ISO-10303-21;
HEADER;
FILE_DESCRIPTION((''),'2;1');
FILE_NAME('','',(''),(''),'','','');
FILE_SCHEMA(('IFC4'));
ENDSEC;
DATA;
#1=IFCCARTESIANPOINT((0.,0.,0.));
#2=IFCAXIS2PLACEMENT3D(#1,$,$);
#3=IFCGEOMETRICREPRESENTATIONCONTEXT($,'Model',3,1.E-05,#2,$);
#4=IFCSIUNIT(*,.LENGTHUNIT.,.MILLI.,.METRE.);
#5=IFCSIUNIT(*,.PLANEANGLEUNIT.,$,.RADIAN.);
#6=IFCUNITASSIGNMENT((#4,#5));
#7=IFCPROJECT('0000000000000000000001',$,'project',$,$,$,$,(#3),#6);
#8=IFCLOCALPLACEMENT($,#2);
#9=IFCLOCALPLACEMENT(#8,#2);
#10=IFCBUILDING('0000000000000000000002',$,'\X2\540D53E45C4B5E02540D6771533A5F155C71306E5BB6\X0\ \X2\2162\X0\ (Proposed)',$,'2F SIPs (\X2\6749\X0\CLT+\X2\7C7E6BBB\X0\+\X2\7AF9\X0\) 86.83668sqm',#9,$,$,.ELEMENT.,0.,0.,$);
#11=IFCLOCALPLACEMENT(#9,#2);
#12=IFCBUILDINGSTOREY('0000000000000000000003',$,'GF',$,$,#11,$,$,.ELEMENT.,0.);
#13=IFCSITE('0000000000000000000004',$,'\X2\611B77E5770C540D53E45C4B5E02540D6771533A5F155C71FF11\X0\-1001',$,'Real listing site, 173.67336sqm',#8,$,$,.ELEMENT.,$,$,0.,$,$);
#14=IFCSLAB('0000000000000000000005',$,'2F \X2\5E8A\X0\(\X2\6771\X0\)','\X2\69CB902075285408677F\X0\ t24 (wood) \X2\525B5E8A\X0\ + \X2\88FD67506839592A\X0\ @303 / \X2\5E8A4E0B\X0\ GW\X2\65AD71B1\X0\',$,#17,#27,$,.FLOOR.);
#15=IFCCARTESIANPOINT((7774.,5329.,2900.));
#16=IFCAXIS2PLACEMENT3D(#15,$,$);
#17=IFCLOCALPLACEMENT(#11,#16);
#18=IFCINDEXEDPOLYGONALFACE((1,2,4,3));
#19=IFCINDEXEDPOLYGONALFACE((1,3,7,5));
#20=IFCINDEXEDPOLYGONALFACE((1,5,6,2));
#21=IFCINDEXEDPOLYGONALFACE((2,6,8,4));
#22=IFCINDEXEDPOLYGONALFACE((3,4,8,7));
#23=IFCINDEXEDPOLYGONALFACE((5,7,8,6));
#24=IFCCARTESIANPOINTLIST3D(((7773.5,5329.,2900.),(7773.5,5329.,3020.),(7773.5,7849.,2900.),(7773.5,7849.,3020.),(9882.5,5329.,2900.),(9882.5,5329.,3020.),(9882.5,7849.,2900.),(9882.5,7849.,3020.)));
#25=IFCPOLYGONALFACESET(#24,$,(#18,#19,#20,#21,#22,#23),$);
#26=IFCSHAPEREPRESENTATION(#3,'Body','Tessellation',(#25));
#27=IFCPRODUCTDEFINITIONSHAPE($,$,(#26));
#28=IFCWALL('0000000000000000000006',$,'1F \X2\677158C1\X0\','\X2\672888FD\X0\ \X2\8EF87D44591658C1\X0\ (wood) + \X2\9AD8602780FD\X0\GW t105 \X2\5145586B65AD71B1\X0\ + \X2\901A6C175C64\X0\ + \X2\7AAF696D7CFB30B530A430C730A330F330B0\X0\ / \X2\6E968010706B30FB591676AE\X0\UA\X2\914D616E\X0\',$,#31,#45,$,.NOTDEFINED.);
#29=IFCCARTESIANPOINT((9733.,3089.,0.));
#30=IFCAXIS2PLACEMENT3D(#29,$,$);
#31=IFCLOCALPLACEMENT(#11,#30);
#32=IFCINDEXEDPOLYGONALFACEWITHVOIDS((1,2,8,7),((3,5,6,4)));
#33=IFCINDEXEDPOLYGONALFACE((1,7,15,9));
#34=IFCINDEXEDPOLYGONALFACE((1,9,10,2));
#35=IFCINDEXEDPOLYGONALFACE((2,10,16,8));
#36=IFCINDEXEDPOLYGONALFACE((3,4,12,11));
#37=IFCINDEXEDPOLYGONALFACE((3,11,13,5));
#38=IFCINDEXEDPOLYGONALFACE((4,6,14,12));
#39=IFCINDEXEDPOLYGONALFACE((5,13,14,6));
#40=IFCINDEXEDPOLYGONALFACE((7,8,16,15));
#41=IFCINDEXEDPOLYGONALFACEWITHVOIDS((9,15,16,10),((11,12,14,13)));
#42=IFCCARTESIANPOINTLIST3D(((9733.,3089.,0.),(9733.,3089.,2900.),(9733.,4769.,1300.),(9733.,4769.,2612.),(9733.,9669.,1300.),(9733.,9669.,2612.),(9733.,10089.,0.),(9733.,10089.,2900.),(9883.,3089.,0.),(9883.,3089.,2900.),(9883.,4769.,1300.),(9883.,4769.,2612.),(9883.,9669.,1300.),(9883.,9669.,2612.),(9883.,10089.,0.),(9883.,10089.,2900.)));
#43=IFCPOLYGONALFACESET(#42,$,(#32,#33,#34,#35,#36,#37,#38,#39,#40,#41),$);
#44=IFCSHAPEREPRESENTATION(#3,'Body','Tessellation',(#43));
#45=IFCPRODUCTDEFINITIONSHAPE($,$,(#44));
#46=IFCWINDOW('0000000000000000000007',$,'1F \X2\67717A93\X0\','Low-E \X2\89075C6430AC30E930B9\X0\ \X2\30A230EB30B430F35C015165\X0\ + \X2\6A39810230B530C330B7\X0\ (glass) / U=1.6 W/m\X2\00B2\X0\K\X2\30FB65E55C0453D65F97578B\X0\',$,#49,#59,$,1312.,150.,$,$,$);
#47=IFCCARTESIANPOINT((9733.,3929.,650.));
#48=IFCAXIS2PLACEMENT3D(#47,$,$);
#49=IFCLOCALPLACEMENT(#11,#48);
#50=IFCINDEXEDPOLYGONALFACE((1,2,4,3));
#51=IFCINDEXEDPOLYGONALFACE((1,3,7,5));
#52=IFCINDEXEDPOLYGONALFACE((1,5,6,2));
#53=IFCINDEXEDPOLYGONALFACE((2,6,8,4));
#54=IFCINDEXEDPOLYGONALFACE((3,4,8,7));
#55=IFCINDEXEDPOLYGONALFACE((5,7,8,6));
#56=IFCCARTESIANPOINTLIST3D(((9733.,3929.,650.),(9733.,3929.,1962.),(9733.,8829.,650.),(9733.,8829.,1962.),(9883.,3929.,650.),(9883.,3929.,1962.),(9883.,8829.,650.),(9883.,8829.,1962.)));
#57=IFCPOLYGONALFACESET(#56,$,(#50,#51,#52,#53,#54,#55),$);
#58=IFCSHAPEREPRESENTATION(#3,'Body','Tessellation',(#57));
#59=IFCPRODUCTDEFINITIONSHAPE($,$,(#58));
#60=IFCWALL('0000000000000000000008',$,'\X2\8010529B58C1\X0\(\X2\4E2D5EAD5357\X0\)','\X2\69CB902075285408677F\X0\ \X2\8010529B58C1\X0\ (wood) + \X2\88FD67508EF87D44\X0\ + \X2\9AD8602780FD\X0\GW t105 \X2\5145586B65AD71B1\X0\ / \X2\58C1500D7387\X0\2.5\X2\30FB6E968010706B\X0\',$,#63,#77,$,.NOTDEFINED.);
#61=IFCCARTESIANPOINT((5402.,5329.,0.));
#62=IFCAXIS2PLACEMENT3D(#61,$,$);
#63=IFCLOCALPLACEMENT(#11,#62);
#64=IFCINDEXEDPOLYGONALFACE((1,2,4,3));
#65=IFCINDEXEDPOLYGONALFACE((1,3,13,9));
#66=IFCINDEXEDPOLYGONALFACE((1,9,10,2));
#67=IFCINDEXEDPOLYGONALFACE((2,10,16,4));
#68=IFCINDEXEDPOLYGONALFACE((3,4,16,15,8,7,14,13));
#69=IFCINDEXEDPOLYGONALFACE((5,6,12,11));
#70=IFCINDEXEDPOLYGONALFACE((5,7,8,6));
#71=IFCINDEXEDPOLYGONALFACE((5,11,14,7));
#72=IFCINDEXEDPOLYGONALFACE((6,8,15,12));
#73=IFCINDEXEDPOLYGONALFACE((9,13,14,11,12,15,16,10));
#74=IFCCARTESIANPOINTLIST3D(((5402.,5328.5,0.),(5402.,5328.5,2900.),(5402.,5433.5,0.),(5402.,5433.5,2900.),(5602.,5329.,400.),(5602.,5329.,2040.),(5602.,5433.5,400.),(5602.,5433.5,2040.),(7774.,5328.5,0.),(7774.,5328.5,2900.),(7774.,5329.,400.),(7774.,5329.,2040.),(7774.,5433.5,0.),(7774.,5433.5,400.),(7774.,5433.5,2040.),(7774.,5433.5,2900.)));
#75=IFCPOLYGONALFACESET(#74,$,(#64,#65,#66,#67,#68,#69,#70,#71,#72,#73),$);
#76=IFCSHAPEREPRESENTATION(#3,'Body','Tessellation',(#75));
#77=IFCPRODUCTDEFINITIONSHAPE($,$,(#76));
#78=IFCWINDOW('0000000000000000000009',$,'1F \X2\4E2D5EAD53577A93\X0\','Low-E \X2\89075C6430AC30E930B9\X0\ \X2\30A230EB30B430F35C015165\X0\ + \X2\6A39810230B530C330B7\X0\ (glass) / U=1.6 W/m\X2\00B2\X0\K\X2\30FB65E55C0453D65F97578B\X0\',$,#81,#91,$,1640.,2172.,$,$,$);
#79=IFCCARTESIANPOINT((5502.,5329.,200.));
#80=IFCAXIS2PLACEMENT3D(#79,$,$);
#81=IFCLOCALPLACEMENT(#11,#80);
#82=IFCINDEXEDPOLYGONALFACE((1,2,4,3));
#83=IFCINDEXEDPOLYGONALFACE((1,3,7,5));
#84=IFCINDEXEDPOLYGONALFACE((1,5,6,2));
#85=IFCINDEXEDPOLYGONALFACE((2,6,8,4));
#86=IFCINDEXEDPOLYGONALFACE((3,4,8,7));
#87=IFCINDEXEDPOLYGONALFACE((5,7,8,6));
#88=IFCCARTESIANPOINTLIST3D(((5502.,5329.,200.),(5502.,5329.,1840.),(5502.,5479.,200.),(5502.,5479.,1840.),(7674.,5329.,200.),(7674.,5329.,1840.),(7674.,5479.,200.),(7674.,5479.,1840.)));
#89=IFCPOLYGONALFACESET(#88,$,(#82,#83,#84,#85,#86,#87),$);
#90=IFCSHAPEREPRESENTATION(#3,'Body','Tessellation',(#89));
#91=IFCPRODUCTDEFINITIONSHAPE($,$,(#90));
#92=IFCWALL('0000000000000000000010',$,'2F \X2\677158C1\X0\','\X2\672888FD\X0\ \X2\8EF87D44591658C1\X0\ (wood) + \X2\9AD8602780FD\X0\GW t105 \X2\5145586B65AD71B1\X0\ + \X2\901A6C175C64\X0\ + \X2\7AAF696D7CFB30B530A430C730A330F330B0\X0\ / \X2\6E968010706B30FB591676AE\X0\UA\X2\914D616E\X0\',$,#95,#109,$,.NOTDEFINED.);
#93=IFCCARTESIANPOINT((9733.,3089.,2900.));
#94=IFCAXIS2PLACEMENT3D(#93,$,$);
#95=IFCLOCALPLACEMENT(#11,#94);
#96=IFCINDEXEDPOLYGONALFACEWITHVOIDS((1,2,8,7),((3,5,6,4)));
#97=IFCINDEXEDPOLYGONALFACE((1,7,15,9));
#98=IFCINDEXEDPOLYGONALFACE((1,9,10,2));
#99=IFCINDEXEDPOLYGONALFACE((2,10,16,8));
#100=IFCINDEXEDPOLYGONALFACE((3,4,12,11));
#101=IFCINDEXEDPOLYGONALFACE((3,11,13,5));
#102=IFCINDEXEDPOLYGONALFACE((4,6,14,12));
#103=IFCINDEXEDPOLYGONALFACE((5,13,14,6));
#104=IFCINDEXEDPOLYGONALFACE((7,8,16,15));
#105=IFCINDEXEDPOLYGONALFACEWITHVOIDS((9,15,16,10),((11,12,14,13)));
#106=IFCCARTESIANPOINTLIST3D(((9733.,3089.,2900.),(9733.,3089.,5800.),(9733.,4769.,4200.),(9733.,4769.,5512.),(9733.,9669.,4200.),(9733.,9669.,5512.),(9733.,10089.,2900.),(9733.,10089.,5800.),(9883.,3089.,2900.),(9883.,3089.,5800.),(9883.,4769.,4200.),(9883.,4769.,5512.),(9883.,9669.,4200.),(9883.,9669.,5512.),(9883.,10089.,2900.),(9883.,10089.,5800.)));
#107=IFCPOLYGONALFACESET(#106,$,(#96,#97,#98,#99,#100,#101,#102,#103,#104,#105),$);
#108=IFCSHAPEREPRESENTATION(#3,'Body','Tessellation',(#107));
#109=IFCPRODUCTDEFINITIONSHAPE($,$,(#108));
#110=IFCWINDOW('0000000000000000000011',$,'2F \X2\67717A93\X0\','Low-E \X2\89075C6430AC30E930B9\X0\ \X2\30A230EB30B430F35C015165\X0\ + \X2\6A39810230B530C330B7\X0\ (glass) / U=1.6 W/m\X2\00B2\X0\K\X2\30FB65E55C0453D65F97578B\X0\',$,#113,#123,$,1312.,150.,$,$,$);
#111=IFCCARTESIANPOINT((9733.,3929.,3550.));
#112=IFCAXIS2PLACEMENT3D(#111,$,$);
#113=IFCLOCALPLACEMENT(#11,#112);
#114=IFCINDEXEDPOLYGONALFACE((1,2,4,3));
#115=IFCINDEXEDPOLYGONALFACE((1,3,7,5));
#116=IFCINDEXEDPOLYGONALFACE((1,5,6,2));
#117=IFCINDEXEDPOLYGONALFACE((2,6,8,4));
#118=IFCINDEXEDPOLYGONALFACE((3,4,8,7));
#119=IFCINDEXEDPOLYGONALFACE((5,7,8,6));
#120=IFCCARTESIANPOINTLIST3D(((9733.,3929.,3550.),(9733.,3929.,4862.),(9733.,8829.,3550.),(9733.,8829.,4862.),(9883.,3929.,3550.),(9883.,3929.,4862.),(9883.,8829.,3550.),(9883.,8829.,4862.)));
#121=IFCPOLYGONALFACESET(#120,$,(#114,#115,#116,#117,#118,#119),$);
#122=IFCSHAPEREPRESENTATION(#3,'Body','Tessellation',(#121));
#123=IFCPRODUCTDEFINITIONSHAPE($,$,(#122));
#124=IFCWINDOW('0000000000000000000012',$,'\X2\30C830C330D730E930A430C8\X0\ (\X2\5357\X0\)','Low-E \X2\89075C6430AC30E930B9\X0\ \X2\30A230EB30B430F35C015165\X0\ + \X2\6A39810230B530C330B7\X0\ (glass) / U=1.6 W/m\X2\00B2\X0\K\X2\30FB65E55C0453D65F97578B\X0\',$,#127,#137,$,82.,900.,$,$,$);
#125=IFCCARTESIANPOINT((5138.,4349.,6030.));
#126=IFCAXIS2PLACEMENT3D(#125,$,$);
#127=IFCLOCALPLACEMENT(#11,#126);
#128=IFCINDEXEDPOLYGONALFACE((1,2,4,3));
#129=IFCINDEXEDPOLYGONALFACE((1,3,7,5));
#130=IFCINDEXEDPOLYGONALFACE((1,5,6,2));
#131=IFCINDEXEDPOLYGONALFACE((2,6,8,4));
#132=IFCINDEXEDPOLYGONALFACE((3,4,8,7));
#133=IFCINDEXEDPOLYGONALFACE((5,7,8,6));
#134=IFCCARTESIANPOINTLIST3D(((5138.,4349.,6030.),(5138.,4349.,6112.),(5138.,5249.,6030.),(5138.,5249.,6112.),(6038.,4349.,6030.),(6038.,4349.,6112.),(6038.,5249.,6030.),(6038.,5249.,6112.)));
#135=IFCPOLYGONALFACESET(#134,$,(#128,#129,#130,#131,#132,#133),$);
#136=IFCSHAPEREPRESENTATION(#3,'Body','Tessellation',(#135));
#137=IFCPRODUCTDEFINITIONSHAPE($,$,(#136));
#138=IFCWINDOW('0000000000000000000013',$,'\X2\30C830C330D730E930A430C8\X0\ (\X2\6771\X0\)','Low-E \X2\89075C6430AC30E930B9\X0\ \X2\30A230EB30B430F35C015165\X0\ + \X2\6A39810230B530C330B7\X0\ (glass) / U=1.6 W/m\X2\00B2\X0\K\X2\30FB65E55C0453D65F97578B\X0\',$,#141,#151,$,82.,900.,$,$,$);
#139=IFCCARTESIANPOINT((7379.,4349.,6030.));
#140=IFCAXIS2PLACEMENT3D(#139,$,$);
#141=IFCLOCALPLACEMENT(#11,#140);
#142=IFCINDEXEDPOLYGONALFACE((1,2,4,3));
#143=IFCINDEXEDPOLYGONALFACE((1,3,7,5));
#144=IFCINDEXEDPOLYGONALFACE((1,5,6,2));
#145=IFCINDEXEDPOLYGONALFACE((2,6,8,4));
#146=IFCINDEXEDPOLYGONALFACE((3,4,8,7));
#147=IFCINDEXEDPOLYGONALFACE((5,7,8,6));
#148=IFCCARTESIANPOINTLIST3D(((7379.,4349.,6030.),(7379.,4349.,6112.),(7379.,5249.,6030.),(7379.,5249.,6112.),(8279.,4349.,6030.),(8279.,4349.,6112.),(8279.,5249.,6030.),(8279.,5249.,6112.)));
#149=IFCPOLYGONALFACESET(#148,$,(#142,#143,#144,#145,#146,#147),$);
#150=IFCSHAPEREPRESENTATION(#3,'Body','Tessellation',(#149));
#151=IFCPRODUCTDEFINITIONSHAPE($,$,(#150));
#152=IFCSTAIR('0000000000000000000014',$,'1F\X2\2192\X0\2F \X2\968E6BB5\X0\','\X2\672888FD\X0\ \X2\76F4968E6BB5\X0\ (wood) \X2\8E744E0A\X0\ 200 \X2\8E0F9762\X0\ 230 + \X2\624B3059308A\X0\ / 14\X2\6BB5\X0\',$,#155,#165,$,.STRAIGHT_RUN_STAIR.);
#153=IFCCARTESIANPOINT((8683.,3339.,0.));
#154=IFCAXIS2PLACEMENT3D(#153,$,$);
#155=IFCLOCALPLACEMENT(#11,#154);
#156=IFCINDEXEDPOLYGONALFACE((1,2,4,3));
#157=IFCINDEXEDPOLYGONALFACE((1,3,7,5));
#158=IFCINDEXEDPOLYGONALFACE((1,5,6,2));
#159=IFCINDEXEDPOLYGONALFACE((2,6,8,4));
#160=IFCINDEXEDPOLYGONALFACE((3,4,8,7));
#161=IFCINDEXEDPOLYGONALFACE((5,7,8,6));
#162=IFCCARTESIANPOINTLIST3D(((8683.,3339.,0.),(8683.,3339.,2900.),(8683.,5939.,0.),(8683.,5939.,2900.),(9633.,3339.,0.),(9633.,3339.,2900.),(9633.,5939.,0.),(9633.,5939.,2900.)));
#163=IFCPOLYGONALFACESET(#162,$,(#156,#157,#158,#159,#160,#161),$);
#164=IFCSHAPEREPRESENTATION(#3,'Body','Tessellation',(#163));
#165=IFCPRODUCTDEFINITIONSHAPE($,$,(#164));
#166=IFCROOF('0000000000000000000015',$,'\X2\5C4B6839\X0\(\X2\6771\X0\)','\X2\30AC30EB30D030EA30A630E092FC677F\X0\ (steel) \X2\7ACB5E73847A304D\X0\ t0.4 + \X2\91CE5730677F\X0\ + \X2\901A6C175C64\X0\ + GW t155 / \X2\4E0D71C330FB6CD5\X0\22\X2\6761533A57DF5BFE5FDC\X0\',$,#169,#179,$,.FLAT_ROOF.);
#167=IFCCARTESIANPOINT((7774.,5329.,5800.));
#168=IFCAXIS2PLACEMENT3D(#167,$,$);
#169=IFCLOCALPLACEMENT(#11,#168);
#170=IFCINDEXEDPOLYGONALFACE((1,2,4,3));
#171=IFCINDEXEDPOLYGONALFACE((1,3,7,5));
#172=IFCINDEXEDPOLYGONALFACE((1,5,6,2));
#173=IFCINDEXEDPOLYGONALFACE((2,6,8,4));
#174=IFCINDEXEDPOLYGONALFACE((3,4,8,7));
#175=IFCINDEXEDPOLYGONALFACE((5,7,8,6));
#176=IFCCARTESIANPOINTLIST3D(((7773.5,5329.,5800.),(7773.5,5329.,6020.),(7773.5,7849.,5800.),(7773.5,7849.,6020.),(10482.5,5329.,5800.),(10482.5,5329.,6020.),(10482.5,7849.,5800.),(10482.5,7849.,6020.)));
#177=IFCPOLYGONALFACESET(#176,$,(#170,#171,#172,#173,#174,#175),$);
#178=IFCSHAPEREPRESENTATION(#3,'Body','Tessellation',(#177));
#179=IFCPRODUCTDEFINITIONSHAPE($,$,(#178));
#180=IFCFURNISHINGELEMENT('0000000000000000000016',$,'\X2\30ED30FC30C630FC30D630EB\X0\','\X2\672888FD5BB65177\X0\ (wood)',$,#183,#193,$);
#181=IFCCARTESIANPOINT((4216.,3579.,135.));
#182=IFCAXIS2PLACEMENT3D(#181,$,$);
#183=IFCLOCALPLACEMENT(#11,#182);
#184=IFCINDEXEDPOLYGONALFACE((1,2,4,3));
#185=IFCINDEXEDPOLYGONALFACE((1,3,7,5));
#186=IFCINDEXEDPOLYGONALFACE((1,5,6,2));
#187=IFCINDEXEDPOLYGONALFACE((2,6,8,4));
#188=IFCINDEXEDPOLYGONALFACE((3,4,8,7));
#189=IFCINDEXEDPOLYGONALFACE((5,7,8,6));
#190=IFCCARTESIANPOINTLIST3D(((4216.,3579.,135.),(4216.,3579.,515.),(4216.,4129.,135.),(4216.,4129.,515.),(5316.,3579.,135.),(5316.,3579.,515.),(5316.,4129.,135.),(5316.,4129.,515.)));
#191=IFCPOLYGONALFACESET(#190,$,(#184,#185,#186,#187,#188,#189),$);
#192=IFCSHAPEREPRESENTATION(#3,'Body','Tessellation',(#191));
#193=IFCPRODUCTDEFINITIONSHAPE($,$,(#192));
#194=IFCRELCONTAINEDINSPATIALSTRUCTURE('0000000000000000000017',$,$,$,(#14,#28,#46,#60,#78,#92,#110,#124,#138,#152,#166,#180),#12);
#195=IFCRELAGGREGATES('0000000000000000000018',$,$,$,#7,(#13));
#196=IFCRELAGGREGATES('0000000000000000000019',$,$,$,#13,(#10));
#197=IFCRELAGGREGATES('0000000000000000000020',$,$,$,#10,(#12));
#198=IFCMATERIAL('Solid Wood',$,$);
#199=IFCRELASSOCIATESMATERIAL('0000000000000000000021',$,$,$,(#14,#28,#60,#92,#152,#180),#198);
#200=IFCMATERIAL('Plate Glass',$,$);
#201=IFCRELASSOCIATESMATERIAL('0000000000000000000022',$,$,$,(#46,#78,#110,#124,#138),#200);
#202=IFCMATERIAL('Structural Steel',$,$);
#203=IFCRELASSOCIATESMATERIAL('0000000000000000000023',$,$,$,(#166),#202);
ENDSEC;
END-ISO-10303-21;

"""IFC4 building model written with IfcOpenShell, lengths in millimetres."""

from ifc_helpers import new_model, si_unit, frame, frame_2d, origin, place, context, project, spatial, rectangle, extrude, material, element, fill, save


model = new_model("IFC4")

# Units and contexts
model_context = context("Model", 3, precision=1e-05, world=origin())
ifc_project = project(units=[si_unit("LENGTHUNIT", "METRE", prefix="MILLI"), si_unit("PLANEANGLEUNIT", "RADIAN")], contexts=[model_context])

# Site, building, storey
site_placement = place(None, origin())
site = spatial("IfcSite", under=ifc_project, at=site_placement, Name="愛知県名古屋市名東区引山１-1001", ObjectType="Real listing site, 173.67336sqm", CompositionType="ELEMENT", RefElevation=0.0)
building_placement = place(site_placement, origin())
building = spatial("IfcBuilding", under=site, at=building_placement, Name="名古屋市名東区引山の家 Ⅲ (Proposed)", ObjectType="2F SIPs (杉CLT+籾殻+竹) 86.83668sqm", CompositionType="ELEMENT", ElevationOfRefHeight=0.0, ElevationOfTerrain=0.0)
storey_placement = place(building_placement, origin())
storey = spatial("IfcBuildingStorey", under=building, at=storey_placement, Name="GF", CompositionType="ELEMENT", Elevation=0.0)

# Slab
ifc_material_1 = material(Name="Solid Wood")
slab_1_placement = place(storey_placement, frame((7774.0, 5329.0, 2900.0)))
element("IfcSlab", 1, at=slab_1_placement, inside=storey, material=ifc_material_1, Name="2F 床(東)", Description="構造用合板 t24 (wood) 剛床 + 製材根太 @303 / 床下 GW断熱", PredefinedType="FLOOR", context=model_context, shape_type="SweptSolid", body=[
    extrude(rectangle(XDim=2109.0, YDim=2520.0, at=frame_2d((1054.0, 1260.0))), frame((7774.0, 5329.0, 2900.0)), (0.0, 0.0, 1.0), 120.0),
])

# Walls, openings, windows
wall_1_placement = place(storey_placement, frame((9733.0, 3089.0, 0.0)))
wall_1 = element("IfcWall", 2, at=wall_1_placement, inside=storey, material=ifc_material_1, Name="1F 東壁", Description="木製 軸組外壁 (wood) + 高性能GW t105 充填断熱 + 通気層 + 窯業系サイディング / 準耐火・外皮UA配慮", PredefinedType="NOTDEFINED", context=model_context, shape_type="SweptSolid", body=[
    extrude(rectangle(XDim=150.0, YDim=7000.0, at=frame_2d((75.0, 3500.0))), frame((9733.0, 3089.0, 0.0)), (0.0, 0.0, 1.0), 2900.0),
])
opening_1_placement = place(storey_placement, frame((9733.0, 3929.0, 650.0)))
opening_1 = element("IfcOpeningElement", 3, at=opening_1_placement, cuts=wall_1, PredefinedType="NOTDEFINED", context=model_context, shape_type="SweptSolid", body=[
    extrude(rectangle(XDim=150.0, YDim=4900.0, at=frame_2d((75.0, 2450.0))), frame((9733.0, 3929.0, 650.0)), (0.0, 0.0, 1.0), 1312.0),
])
ifc_material_2 = material(Name="Plate Glass")
window_1_placement = place(storey_placement, frame((9733.0, 3929.0, 650.0)))
window_1 = element("IfcWindow", 4, at=window_1_placement, inside=storey, material=ifc_material_2, Name="1F 東窓", Description="Low-E 複層ガラス アルゴン封入 + 樹脂サッシ (glass) / U=1.6 W/m²K・日射取得型", OverallHeight=1312.0, OverallWidth=150.0, context=model_context, shape_type="SweptSolid", body=[
    extrude(rectangle(XDim=150.0, YDim=4900.0, at=frame_2d((75.0, 2450.0))), frame((9733.0, 3929.0, 650.0)), (0.0, 0.0, 1.0), 1312.0),
])
fill(opening_1, window_1)
wall_2_placement = place(storey_placement, frame((5402.0, 5329.0, 0.0)))
wall_2 = element("IfcWall", 5, at=wall_2_placement, inside=storey, material=ifc_material_1, Name="耐力壁(中庭南)", Description="構造用合板 耐力壁 (wood) + 製材軸組 + 高性能GW t105 充填断熱 / 壁倍率2.5・準耐火", PredefinedType="NOTDEFINED", context=model_context, shape_type="SweptSolid", body=[
    extrude(rectangle(XDim=2372.0, YDim=105.0, at=frame_2d((1186.0, 52.0))), frame((5402.0, 5329.0, 0.0)), (0.0, 0.0, 1.0), 2900.0),
])
opening_2_placement = place(storey_placement, frame((5502.0, 5329.0, 200.0)))
opening_2 = element("IfcOpeningElement", 6, at=opening_2_placement, cuts=wall_2, PredefinedType="NOTDEFINED", context=model_context, shape_type="SweptSolid", body=[
    extrude(rectangle(XDim=2172.0, YDim=150.0, at=frame_2d((1086.0, 75.0))), frame((5502.0, 5329.0, 200.0)), (0.0, 0.0, 1.0), 1640.0),
])
window_2_placement = place(storey_placement, frame((5502.0, 5329.0, 200.0)))
window_2 = element("IfcWindow", 7, at=window_2_placement, inside=storey, material=ifc_material_2, Name="1F 中庭南窓", Description="Low-E 複層ガラス アルゴン封入 + 樹脂サッシ (glass) / U=1.6 W/m²K・日射取得型", OverallHeight=1640.0, OverallWidth=2172.0, context=model_context, shape_type="SweptSolid", body=[
    extrude(rectangle(XDim=2172.0, YDim=150.0, at=frame_2d((1086.0, 75.0))), frame((5502.0, 5329.0, 200.0)), (0.0, 0.0, 1.0), 1640.0),
])
fill(opening_2, window_2)

# Wall, opening, window
wall_3_placement = place(storey_placement, frame((9733.0, 3089.0, 2900.0)))
wall_3 = element("IfcWall", 8, at=wall_3_placement, inside=storey, material=ifc_material_1, Name="2F 東壁", Description="木製 軸組外壁 (wood) + 高性能GW t105 充填断熱 + 通気層 + 窯業系サイディング / 準耐火・外皮UA配慮", PredefinedType="NOTDEFINED", context=model_context, shape_type="SweptSolid", body=[
    extrude(rectangle(XDim=150.0, YDim=7000.0, at=frame_2d((75.0, 3500.0))), frame((9733.0, 3089.0, 2900.0)), (0.0, 0.0, 1.0), 2900.0),
])
opening_3_placement = place(storey_placement, frame((9733.0, 3929.0, 3550.0)))
opening_3 = element("IfcOpeningElement", 9, at=opening_3_placement, cuts=wall_3, PredefinedType="NOTDEFINED", context=model_context, shape_type="SweptSolid", body=[
    extrude(rectangle(XDim=150.0, YDim=4900.0, at=frame_2d((75.0, 2450.0))), frame((9733.0, 3929.0, 3550.0)), (0.0, 0.0, 1.0), 1312.0),
])
window_3_placement = place(storey_placement, frame((9733.0, 3929.0, 3550.0)))
window_3 = element("IfcWindow", 10, at=window_3_placement, inside=storey, material=ifc_material_2, Name="2F 東窓", Description="Low-E 複層ガラス アルゴン封入 + 樹脂サッシ (glass) / U=1.6 W/m²K・日射取得型", OverallHeight=1312.0, OverallWidth=150.0, context=model_context, shape_type="SweptSolid", body=[
    extrude(rectangle(XDim=150.0, YDim=4900.0, at=frame_2d((75.0, 2450.0))), frame((9733.0, 3929.0, 3550.0)), (0.0, 0.0, 1.0), 1312.0),
])
fill(opening_3, window_3)

# Windows
window_4_placement = place(storey_placement, frame((5138.0, 4349.0, 6030.0)))
element("IfcWindow", 11, at=window_4_placement, inside=storey, material=ifc_material_2, Name="トップライト (南)", Description="Low-E 複層ガラス アルゴン封入 + 樹脂サッシ (glass) / U=1.6 W/m²K・日射取得型", OverallHeight=82.0, OverallWidth=900.0, context=model_context, shape_type="SweptSolid", body=[
    extrude(rectangle(XDim=900.0, YDim=900.0, at=frame_2d((450.0, 450.0))), frame((5138.0, 4349.0, 6030.0)), (0.0, 0.0, 1.0), 82.0),
])
window_5_placement = place(storey_placement, frame((7379.0, 4349.0, 6030.0)))
element("IfcWindow", 12, at=window_5_placement, inside=storey, material=ifc_material_2, Name="トップライト (東)", Description="Low-E 複層ガラス アルゴン封入 + 樹脂サッシ (glass) / U=1.6 W/m²K・日射取得型", OverallHeight=82.0, OverallWidth=900.0, context=model_context, shape_type="SweptSolid", body=[
    extrude(rectangle(XDim=900.0, YDim=900.0, at=frame_2d((450.0, 450.0))), frame((7379.0, 4349.0, 6030.0)), (0.0, 0.0, 1.0), 82.0),
])

# Stair
stair_placement = place(storey_placement, frame((8683.0, 3339.0, 0.0)))
element("IfcStair", 13, at=stair_placement, inside=storey, material=ifc_material_1, Name="1F→2F 階段", Description="木製 直階段 (wood) 蹴上 200 踏面 230 + 手すり / 14段", PredefinedType="STRAIGHT_RUN_STAIR", context=model_context, shape_type="SweptSolid", body=[
    extrude(rectangle(XDim=950.0, YDim=2600.0, at=frame_2d((475.0, 1300.0))), frame((8683.0, 3339.0, 0.0)), (0.0, 0.0, 1.0), 2900.0),
])

# Roof
ifc_material_3 = material(Name="Structural Steel")
roof_placement = place(storey_placement, frame((7774.0, 5329.0, 5800.0)))
element("IfcRoof", 14, at=roof_placement, inside=storey, material=ifc_material_3, Name="屋根(東)", Description="ガルバリウム鋼板 (steel) 立平葺き t0.4 + 野地板 + 通気層 + GW t155 / 不燃・法22条区域対応", PredefinedType="FLAT_ROOF", context=model_context, shape_type="SweptSolid", body=[
    extrude(rectangle(XDim=2709.0, YDim=2520.0, at=frame_2d((1354.0, 1260.0))), frame((7774.0, 5329.0, 5800.0)), (0.0, 0.0, 1.0), 220.0),
])

# Furnishing element
furnishing_1_placement = place(storey_placement, frame((4216.0, 3579.0, 135.0)))
element("IfcFurnishingElement", 15, at=furnishing_1_placement, inside=storey, material=ifc_material_1, Name="ローテーブル", Description="木製家具 (wood)", context=model_context, shape_type="SweptSolid", body=[
    extrude(rectangle(XDim=1100.0, YDim=550.0, at=frame_2d((550.0, 275.0))), frame((4216.0, 3579.0, 135.0)), (0.0, 0.0, 1.0), 380.0),
])

save(model, "model.ifc")
